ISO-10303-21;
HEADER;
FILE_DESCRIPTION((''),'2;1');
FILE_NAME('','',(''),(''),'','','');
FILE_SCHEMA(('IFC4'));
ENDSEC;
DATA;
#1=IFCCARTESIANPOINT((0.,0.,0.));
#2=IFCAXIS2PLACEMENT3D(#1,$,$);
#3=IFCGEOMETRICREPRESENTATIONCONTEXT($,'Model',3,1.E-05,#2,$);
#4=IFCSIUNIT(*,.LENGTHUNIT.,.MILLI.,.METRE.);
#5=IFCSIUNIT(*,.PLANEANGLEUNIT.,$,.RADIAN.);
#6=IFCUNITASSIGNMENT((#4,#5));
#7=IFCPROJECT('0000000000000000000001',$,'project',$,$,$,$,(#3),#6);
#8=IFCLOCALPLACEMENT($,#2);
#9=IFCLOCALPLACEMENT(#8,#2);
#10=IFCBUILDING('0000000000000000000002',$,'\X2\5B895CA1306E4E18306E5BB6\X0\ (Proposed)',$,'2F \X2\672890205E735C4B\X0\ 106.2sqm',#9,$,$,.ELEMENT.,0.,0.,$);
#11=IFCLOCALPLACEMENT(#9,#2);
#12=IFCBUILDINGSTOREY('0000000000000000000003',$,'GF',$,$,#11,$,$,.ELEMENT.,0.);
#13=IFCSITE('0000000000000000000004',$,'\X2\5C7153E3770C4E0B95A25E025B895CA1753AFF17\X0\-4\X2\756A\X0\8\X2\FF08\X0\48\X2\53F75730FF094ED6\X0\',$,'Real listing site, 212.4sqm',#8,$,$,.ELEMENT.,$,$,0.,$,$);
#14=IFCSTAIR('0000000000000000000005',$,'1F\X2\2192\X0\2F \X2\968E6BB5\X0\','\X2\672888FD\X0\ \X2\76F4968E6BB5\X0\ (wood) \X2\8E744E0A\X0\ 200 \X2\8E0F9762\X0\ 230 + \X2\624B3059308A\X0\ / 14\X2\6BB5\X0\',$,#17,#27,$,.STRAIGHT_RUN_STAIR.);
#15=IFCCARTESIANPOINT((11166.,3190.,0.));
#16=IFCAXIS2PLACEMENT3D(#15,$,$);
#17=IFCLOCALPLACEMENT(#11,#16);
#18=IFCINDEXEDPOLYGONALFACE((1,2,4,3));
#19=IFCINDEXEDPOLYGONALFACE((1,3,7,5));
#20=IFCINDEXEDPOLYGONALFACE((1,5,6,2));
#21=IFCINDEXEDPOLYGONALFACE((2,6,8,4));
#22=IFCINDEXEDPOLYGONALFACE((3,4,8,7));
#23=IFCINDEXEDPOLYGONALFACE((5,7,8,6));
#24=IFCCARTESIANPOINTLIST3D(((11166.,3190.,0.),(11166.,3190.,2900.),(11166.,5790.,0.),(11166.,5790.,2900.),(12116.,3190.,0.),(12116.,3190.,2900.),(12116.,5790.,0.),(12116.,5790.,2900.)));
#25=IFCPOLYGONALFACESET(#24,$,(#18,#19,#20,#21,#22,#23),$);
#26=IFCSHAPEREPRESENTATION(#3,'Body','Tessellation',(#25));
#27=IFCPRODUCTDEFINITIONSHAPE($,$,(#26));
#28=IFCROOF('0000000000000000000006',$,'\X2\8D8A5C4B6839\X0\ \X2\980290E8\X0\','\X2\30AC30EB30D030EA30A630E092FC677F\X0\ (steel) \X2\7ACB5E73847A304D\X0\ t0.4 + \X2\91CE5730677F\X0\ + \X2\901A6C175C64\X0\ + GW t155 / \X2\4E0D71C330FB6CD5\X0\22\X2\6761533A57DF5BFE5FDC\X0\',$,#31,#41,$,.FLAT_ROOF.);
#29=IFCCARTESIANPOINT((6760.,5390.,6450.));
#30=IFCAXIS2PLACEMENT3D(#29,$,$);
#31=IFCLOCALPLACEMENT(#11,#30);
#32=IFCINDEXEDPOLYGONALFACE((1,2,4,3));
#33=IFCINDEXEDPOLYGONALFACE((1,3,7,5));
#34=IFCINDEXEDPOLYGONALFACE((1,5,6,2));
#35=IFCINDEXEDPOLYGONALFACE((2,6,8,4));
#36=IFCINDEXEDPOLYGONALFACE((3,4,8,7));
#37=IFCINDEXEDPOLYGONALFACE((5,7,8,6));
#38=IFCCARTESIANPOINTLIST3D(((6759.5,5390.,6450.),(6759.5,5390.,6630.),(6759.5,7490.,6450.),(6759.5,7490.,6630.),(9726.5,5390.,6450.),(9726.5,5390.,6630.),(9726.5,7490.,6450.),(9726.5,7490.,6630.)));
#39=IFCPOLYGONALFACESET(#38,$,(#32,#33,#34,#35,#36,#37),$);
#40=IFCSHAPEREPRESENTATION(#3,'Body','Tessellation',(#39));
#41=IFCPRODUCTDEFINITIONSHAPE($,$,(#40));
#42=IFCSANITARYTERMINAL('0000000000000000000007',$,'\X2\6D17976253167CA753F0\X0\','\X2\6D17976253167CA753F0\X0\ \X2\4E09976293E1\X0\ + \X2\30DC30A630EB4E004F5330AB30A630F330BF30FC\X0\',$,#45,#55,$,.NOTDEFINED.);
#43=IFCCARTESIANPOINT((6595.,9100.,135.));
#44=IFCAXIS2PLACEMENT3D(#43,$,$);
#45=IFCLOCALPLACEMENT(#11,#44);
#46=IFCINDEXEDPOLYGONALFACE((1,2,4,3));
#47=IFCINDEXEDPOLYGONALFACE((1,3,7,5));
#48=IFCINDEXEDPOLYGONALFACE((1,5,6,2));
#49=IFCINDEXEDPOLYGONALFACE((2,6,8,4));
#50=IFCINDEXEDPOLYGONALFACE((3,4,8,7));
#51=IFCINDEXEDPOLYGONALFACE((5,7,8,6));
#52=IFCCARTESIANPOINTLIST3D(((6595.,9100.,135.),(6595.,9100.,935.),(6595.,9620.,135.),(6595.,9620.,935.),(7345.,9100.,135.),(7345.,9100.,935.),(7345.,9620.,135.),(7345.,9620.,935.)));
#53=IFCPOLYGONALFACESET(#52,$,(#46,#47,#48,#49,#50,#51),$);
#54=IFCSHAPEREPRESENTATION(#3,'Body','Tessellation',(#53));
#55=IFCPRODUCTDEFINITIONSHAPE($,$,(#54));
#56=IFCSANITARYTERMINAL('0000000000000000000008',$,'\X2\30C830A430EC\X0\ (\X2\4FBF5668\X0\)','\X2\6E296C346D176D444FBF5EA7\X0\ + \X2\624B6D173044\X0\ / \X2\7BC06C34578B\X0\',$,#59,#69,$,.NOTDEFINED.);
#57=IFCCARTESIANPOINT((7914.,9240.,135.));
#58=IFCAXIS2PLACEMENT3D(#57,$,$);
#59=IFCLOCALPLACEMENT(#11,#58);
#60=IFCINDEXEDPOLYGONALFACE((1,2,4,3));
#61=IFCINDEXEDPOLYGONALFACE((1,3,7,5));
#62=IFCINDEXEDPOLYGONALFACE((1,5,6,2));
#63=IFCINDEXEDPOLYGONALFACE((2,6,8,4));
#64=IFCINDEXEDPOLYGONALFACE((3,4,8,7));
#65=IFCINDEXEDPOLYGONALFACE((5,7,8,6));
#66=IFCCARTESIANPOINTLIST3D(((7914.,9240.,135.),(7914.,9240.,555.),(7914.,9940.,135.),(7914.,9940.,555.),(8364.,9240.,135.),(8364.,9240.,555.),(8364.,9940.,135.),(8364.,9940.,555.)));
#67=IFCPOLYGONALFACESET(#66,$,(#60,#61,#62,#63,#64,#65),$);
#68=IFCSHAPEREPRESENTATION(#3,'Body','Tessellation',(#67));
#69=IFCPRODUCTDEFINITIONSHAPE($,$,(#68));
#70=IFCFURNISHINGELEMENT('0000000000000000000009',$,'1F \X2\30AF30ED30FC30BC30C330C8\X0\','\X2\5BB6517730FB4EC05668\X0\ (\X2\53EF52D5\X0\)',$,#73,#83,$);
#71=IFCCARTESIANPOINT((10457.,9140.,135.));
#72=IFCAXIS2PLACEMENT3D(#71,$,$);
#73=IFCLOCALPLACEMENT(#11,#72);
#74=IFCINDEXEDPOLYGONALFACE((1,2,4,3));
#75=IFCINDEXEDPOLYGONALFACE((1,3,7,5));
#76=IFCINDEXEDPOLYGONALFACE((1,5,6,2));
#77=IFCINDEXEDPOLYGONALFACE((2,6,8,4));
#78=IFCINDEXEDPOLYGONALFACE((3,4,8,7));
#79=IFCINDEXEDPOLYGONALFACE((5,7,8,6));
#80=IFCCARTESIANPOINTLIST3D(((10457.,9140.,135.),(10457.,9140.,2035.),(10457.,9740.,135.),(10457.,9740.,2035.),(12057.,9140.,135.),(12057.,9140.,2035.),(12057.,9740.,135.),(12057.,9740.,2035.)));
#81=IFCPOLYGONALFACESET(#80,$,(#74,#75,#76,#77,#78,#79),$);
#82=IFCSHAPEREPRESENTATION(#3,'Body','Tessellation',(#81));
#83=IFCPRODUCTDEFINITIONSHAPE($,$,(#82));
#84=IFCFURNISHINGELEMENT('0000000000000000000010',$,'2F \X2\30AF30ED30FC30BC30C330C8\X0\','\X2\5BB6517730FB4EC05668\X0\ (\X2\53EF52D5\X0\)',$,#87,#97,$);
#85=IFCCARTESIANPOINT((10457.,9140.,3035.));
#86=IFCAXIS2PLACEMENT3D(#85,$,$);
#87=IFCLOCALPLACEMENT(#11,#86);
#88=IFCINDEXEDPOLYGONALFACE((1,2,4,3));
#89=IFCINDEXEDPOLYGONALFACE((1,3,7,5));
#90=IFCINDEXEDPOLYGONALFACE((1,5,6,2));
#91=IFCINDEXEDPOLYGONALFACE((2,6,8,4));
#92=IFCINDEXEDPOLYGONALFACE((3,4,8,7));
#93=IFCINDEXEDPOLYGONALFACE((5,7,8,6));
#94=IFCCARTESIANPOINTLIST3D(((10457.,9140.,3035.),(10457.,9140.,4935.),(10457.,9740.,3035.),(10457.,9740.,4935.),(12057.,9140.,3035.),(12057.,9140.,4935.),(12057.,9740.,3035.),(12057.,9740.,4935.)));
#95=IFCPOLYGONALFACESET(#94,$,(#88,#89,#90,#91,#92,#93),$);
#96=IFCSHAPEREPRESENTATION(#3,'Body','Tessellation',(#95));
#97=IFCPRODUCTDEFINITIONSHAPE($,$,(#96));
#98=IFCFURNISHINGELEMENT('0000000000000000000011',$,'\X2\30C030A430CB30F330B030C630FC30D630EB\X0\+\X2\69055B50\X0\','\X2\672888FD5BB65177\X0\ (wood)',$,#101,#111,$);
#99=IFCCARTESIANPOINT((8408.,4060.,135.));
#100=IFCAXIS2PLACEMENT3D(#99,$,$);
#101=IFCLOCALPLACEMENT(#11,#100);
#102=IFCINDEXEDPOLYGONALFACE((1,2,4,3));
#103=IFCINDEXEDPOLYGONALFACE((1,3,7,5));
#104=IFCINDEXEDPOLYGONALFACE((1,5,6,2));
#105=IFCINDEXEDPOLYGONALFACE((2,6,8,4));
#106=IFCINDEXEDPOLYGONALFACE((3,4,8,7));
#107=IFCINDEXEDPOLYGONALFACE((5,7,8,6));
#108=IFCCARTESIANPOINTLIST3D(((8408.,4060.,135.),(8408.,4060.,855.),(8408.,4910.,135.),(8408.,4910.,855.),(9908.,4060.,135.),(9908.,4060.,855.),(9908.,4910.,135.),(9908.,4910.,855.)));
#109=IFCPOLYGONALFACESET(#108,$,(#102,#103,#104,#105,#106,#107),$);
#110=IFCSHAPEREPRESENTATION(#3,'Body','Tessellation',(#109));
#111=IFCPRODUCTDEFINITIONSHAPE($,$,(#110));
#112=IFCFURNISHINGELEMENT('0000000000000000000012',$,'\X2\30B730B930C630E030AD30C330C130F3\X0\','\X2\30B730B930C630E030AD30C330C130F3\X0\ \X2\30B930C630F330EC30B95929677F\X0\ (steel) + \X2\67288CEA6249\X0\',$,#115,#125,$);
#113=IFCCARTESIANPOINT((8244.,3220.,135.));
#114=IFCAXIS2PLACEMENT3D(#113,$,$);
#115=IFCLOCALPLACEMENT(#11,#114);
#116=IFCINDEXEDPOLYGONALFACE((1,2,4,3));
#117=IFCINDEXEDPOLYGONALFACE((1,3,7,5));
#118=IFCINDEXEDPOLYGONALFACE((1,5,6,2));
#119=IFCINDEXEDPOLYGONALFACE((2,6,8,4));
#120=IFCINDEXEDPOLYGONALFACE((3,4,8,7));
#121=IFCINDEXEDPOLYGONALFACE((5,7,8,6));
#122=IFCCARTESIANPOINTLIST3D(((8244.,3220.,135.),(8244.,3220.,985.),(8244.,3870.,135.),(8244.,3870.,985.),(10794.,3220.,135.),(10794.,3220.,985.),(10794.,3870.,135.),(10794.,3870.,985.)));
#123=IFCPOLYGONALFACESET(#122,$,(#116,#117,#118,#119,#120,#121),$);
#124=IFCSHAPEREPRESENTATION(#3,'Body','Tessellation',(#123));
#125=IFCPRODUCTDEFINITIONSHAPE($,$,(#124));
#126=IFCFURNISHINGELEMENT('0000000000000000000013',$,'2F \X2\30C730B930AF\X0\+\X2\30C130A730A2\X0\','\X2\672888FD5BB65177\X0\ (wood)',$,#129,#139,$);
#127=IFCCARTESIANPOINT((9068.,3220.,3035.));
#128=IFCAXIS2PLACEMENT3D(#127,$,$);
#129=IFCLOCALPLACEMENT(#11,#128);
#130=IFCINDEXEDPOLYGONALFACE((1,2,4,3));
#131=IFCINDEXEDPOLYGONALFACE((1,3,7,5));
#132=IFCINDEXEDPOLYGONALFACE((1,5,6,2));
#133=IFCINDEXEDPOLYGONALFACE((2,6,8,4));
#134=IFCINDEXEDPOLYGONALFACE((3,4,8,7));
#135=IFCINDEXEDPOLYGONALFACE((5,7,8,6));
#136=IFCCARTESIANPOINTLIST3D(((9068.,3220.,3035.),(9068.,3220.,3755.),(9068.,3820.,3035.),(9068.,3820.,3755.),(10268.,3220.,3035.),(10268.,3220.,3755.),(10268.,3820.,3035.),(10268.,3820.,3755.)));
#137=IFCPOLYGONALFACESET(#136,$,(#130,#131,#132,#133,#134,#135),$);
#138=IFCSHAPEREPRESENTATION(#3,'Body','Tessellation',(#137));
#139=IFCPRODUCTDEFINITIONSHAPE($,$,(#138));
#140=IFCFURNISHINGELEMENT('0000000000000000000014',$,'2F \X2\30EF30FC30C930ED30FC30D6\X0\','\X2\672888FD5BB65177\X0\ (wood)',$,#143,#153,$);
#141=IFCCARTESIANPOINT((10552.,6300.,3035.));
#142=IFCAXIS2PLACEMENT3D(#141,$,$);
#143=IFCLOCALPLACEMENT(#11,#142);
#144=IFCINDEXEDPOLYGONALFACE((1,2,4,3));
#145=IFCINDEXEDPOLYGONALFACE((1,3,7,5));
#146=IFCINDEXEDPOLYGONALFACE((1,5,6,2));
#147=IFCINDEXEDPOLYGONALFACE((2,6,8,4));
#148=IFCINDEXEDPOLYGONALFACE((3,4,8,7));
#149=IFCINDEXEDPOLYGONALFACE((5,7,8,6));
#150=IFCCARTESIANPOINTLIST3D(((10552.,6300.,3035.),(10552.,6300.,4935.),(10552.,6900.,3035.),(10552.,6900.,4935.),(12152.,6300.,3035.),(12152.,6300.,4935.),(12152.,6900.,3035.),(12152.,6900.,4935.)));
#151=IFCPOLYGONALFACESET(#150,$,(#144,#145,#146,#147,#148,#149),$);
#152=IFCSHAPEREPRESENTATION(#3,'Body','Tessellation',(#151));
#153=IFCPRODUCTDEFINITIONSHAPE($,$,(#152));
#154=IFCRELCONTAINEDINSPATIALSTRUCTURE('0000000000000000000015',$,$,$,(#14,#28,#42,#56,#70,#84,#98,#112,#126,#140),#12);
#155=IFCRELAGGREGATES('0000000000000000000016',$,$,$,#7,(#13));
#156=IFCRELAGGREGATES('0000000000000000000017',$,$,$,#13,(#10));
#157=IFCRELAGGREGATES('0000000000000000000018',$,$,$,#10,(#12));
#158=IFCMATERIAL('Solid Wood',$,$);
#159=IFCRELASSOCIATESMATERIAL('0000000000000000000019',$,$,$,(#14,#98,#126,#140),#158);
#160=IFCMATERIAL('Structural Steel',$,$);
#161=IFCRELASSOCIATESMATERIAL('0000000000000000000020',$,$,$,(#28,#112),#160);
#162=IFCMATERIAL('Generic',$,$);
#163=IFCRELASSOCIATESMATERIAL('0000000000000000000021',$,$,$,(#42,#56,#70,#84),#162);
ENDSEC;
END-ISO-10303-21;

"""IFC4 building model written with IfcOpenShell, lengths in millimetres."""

from ifc_helpers import new_model, si_unit, frame, frame_2d, origin, place, context, project, spatial, rectangle, extrude, material, element, save


model = new_model("IFC4")

# Units and contexts
model_context = context("Model", 3, precision=1e-05, world=origin())
ifc_project = project(units=[si_unit("LENGTHUNIT", "METRE", prefix="MILLI"), si_unit("PLANEANGLEUNIT", "RADIAN")], contexts=[model_context])

# Site, building, storey
site_placement = place(None, origin())
site = spatial("IfcSite", under=ifc_project, at=site_placement, Name="山口県下関市安岡町７-4番8（48号地）他", ObjectType="Real listing site, 212.4sqm", CompositionType="ELEMENT", RefElevation=0.0)
building_placement = place(site_placement, origin())
building = spatial("IfcBuilding", under=site, at=building_placement, Name="安岡の丘の家 (Proposed)", ObjectType="2F 木造平屋 106.2sqm", CompositionType="ELEMENT", ElevationOfRefHeight=0.0, ElevationOfTerrain=0.0)
storey_placement = place(building_placement, origin())
storey = spatial("IfcBuildingStorey", under=building, at=storey_placement, Name="GF", CompositionType="ELEMENT", Elevation=0.0)

# Shared definitions
ifc_material_1 = material(Name="Solid Wood")

# Stair
stair_placement = place(storey_placement, frame((11166.0, 3190.0, 0.0)))
element("IfcStair", 1, at=stair_placement, inside=storey, material=ifc_material_1, Name="1F→2F 階段", Description="木製 直階段 (wood) 蹴上 200 踏面 230 + 手すり / 14段", PredefinedType="STRAIGHT_RUN_STAIR", context=model_context, shape_type="SweptSolid", body=[
    extrude(rectangle(XDim=950.0, YDim=2600.0, at=frame_2d((475.0, 1300.0))), frame((11166.0, 3190.0, 0.0)), (0.0, 0.0, 1.0), 2900.0),
])

# Roof
ifc_material_2 = material(Name="Structural Steel")
roof_placement = place(storey_placement, frame((6760.0, 5390.0, 6450.0)))
element("IfcRoof", 2, at=roof_placement, inside=storey, material=ifc_material_2, Name="越屋根 頂部", Description="ガルバリウム鋼板 (steel) 立平葺き t0.4 + 野地板 + 通気層 + GW t155 / 不燃・法22条区域対応", PredefinedType="FLAT_ROOF", context=model_context, shape_type="SweptSolid", body=[
    extrude(rectangle(XDim=2967.0, YDim=2100.0, at=frame_2d((1483.0, 1050.0))), frame((6760.0, 5390.0, 6450.0)), (0.0, 0.0, 1.0), 180.0),
])

# Sanitary terminals
ifc_material_3 = material(Name="Generic")
sanitary_terminal_1_placement = place(storey_placement, frame((6595.0, 9100.0, 135.0)))
element("IfcSanitaryTerminal", 3, at=sanitary_terminal_1_placement, inside=storey, material=ifc_material_3, Name="洗面化粧台", Description="洗面化粧台 三面鏡 + ボウル一体カウンター", PredefinedType="NOTDEFINED", context=model_context, shape_type="SweptSolid", body=[
    extrude(rectangle(XDim=750.0, YDim=520.0, at=frame_2d((375.0, 260.0))), frame((6595.0, 9100.0, 135.0)), (0.0, 0.0, 1.0), 800.0),
])
sanitary_terminal_2_placement = place(storey_placement, frame((7914.0, 9240.0, 135.0)))
element("IfcSanitaryTerminal", 4, at=sanitary_terminal_2_placement, inside=storey, material=ifc_material_3, Name="トイレ (便器)", Description="温水洗浄便座 + 手洗い / 節水型", PredefinedType="NOTDEFINED", context=model_context, shape_type="SweptSolid", body=[
    extrude(rectangle(XDim=450.0, YDim=700.0, at=frame_2d((225.0, 350.0))), frame((7914.0, 9240.0, 135.0)), (0.0, 0.0, 1.0), 420.0),
])

# Furnishing elements
furnishing_1_placement = place(storey_placement, frame((10457.0, 9140.0, 135.0)))
element("IfcFurnishingElement", 5, at=furnishing_1_placement, inside=storey, material=ifc_material_3, Name="1F クローゼット", Description="家具・什器 (可動)", context=model_context, shape_type="SweptSolid", body=[
    extrude(rectangle(XDim=1600.0, YDim=600.0, at=frame_2d((800.0, 300.0))), frame((10457.0, 9140.0, 135.0)), (0.0, 0.0, 1.0), 1900.0),
])
furnishing_2_placement = place(storey_placement, frame((10457.0, 9140.0, 3035.0)))
element("IfcFurnishingElement", 6, at=furnishing_2_placement, inside=storey, material=ifc_material_3, Name="2F クローゼット", Description="家具・什器 (可動)", context=model_context, shape_type="SweptSolid", body=[
    extrude(rectangle(XDim=1600.0, YDim=600.0, at=frame_2d((800.0, 300.0))), frame((10457.0, 9140.0, 3035.0)), (0.0, 0.0, 1.0), 1900.0),
])
furnishing_3_placement = place(storey_placement, frame((8408.0, 4060.0, 135.0)))
element("IfcFurnishingElement", 7, at=furnishing_3_placement, inside=storey, material=ifc_material_1, Name="ダイニングテーブル+椅子", Description="木製家具 (wood)", context=model_context, shape_type="SweptSolid", body=[
    extrude(rectangle(XDim=1500.0, YDim=850.0, at=frame_2d((750.0, 425.0))), frame((8408.0, 4060.0, 135.0)), (0.0, 0.0, 1.0), 720.0),
])
furnishing_4_placement = place(storey_placement, frame((8244.0, 3220.0, 135.0)))
element("IfcFurnishingElement", 8, at=furnishing_4_placement, inside=storey, material=ifc_material_2, Name="システムキッチン", Description="システムキッチン ステンレス天板 (steel) + 木質扉", context=model_context, shape_type="SweptSolid", body=[
    extrude(rectangle(XDim=2550.0, YDim=650.0, at=frame_2d((1275.0, 325.0))), frame((8244.0, 3220.0, 135.0)), (0.0, 0.0, 1.0), 850.0),
])
furnishing_5_placement = place(storey_placement, frame((9068.0, 3220.0, 3035.0)))
element("IfcFurnishingElement", 9, at=furnishing_5_placement, inside=storey, material=ifc_material_1, Name="2F デスク+チェア", Description="木製家具 (wood)", context=model_context, shape_type="SweptSolid", body=[
    extrude(rectangle(XDim=1200.0, YDim=600.0, at=frame_2d((600.0, 300.0))), frame((9068.0, 3220.0, 3035.0)), (0.0, 0.0, 1.0), 720.0),
])
furnishing_6_placement = place(storey_placement, frame((10552.0, 6300.0, 3035.0)))
element("IfcFurnishingElement", 10, at=furnishing_6_placement, inside=storey, material=ifc_material_1, Name="2F ワードローブ", Description="木製家具 (wood)", context=model_context, shape_type="SweptSolid", body=[
    extrude(rectangle(XDim=1600.0, YDim=600.0, at=frame_2d((800.0, 300.0))), frame((10552.0, 6300.0, 3035.0)), (0.0, 0.0, 1.0), 1900.0),
])

save(model, "model.ifc")
